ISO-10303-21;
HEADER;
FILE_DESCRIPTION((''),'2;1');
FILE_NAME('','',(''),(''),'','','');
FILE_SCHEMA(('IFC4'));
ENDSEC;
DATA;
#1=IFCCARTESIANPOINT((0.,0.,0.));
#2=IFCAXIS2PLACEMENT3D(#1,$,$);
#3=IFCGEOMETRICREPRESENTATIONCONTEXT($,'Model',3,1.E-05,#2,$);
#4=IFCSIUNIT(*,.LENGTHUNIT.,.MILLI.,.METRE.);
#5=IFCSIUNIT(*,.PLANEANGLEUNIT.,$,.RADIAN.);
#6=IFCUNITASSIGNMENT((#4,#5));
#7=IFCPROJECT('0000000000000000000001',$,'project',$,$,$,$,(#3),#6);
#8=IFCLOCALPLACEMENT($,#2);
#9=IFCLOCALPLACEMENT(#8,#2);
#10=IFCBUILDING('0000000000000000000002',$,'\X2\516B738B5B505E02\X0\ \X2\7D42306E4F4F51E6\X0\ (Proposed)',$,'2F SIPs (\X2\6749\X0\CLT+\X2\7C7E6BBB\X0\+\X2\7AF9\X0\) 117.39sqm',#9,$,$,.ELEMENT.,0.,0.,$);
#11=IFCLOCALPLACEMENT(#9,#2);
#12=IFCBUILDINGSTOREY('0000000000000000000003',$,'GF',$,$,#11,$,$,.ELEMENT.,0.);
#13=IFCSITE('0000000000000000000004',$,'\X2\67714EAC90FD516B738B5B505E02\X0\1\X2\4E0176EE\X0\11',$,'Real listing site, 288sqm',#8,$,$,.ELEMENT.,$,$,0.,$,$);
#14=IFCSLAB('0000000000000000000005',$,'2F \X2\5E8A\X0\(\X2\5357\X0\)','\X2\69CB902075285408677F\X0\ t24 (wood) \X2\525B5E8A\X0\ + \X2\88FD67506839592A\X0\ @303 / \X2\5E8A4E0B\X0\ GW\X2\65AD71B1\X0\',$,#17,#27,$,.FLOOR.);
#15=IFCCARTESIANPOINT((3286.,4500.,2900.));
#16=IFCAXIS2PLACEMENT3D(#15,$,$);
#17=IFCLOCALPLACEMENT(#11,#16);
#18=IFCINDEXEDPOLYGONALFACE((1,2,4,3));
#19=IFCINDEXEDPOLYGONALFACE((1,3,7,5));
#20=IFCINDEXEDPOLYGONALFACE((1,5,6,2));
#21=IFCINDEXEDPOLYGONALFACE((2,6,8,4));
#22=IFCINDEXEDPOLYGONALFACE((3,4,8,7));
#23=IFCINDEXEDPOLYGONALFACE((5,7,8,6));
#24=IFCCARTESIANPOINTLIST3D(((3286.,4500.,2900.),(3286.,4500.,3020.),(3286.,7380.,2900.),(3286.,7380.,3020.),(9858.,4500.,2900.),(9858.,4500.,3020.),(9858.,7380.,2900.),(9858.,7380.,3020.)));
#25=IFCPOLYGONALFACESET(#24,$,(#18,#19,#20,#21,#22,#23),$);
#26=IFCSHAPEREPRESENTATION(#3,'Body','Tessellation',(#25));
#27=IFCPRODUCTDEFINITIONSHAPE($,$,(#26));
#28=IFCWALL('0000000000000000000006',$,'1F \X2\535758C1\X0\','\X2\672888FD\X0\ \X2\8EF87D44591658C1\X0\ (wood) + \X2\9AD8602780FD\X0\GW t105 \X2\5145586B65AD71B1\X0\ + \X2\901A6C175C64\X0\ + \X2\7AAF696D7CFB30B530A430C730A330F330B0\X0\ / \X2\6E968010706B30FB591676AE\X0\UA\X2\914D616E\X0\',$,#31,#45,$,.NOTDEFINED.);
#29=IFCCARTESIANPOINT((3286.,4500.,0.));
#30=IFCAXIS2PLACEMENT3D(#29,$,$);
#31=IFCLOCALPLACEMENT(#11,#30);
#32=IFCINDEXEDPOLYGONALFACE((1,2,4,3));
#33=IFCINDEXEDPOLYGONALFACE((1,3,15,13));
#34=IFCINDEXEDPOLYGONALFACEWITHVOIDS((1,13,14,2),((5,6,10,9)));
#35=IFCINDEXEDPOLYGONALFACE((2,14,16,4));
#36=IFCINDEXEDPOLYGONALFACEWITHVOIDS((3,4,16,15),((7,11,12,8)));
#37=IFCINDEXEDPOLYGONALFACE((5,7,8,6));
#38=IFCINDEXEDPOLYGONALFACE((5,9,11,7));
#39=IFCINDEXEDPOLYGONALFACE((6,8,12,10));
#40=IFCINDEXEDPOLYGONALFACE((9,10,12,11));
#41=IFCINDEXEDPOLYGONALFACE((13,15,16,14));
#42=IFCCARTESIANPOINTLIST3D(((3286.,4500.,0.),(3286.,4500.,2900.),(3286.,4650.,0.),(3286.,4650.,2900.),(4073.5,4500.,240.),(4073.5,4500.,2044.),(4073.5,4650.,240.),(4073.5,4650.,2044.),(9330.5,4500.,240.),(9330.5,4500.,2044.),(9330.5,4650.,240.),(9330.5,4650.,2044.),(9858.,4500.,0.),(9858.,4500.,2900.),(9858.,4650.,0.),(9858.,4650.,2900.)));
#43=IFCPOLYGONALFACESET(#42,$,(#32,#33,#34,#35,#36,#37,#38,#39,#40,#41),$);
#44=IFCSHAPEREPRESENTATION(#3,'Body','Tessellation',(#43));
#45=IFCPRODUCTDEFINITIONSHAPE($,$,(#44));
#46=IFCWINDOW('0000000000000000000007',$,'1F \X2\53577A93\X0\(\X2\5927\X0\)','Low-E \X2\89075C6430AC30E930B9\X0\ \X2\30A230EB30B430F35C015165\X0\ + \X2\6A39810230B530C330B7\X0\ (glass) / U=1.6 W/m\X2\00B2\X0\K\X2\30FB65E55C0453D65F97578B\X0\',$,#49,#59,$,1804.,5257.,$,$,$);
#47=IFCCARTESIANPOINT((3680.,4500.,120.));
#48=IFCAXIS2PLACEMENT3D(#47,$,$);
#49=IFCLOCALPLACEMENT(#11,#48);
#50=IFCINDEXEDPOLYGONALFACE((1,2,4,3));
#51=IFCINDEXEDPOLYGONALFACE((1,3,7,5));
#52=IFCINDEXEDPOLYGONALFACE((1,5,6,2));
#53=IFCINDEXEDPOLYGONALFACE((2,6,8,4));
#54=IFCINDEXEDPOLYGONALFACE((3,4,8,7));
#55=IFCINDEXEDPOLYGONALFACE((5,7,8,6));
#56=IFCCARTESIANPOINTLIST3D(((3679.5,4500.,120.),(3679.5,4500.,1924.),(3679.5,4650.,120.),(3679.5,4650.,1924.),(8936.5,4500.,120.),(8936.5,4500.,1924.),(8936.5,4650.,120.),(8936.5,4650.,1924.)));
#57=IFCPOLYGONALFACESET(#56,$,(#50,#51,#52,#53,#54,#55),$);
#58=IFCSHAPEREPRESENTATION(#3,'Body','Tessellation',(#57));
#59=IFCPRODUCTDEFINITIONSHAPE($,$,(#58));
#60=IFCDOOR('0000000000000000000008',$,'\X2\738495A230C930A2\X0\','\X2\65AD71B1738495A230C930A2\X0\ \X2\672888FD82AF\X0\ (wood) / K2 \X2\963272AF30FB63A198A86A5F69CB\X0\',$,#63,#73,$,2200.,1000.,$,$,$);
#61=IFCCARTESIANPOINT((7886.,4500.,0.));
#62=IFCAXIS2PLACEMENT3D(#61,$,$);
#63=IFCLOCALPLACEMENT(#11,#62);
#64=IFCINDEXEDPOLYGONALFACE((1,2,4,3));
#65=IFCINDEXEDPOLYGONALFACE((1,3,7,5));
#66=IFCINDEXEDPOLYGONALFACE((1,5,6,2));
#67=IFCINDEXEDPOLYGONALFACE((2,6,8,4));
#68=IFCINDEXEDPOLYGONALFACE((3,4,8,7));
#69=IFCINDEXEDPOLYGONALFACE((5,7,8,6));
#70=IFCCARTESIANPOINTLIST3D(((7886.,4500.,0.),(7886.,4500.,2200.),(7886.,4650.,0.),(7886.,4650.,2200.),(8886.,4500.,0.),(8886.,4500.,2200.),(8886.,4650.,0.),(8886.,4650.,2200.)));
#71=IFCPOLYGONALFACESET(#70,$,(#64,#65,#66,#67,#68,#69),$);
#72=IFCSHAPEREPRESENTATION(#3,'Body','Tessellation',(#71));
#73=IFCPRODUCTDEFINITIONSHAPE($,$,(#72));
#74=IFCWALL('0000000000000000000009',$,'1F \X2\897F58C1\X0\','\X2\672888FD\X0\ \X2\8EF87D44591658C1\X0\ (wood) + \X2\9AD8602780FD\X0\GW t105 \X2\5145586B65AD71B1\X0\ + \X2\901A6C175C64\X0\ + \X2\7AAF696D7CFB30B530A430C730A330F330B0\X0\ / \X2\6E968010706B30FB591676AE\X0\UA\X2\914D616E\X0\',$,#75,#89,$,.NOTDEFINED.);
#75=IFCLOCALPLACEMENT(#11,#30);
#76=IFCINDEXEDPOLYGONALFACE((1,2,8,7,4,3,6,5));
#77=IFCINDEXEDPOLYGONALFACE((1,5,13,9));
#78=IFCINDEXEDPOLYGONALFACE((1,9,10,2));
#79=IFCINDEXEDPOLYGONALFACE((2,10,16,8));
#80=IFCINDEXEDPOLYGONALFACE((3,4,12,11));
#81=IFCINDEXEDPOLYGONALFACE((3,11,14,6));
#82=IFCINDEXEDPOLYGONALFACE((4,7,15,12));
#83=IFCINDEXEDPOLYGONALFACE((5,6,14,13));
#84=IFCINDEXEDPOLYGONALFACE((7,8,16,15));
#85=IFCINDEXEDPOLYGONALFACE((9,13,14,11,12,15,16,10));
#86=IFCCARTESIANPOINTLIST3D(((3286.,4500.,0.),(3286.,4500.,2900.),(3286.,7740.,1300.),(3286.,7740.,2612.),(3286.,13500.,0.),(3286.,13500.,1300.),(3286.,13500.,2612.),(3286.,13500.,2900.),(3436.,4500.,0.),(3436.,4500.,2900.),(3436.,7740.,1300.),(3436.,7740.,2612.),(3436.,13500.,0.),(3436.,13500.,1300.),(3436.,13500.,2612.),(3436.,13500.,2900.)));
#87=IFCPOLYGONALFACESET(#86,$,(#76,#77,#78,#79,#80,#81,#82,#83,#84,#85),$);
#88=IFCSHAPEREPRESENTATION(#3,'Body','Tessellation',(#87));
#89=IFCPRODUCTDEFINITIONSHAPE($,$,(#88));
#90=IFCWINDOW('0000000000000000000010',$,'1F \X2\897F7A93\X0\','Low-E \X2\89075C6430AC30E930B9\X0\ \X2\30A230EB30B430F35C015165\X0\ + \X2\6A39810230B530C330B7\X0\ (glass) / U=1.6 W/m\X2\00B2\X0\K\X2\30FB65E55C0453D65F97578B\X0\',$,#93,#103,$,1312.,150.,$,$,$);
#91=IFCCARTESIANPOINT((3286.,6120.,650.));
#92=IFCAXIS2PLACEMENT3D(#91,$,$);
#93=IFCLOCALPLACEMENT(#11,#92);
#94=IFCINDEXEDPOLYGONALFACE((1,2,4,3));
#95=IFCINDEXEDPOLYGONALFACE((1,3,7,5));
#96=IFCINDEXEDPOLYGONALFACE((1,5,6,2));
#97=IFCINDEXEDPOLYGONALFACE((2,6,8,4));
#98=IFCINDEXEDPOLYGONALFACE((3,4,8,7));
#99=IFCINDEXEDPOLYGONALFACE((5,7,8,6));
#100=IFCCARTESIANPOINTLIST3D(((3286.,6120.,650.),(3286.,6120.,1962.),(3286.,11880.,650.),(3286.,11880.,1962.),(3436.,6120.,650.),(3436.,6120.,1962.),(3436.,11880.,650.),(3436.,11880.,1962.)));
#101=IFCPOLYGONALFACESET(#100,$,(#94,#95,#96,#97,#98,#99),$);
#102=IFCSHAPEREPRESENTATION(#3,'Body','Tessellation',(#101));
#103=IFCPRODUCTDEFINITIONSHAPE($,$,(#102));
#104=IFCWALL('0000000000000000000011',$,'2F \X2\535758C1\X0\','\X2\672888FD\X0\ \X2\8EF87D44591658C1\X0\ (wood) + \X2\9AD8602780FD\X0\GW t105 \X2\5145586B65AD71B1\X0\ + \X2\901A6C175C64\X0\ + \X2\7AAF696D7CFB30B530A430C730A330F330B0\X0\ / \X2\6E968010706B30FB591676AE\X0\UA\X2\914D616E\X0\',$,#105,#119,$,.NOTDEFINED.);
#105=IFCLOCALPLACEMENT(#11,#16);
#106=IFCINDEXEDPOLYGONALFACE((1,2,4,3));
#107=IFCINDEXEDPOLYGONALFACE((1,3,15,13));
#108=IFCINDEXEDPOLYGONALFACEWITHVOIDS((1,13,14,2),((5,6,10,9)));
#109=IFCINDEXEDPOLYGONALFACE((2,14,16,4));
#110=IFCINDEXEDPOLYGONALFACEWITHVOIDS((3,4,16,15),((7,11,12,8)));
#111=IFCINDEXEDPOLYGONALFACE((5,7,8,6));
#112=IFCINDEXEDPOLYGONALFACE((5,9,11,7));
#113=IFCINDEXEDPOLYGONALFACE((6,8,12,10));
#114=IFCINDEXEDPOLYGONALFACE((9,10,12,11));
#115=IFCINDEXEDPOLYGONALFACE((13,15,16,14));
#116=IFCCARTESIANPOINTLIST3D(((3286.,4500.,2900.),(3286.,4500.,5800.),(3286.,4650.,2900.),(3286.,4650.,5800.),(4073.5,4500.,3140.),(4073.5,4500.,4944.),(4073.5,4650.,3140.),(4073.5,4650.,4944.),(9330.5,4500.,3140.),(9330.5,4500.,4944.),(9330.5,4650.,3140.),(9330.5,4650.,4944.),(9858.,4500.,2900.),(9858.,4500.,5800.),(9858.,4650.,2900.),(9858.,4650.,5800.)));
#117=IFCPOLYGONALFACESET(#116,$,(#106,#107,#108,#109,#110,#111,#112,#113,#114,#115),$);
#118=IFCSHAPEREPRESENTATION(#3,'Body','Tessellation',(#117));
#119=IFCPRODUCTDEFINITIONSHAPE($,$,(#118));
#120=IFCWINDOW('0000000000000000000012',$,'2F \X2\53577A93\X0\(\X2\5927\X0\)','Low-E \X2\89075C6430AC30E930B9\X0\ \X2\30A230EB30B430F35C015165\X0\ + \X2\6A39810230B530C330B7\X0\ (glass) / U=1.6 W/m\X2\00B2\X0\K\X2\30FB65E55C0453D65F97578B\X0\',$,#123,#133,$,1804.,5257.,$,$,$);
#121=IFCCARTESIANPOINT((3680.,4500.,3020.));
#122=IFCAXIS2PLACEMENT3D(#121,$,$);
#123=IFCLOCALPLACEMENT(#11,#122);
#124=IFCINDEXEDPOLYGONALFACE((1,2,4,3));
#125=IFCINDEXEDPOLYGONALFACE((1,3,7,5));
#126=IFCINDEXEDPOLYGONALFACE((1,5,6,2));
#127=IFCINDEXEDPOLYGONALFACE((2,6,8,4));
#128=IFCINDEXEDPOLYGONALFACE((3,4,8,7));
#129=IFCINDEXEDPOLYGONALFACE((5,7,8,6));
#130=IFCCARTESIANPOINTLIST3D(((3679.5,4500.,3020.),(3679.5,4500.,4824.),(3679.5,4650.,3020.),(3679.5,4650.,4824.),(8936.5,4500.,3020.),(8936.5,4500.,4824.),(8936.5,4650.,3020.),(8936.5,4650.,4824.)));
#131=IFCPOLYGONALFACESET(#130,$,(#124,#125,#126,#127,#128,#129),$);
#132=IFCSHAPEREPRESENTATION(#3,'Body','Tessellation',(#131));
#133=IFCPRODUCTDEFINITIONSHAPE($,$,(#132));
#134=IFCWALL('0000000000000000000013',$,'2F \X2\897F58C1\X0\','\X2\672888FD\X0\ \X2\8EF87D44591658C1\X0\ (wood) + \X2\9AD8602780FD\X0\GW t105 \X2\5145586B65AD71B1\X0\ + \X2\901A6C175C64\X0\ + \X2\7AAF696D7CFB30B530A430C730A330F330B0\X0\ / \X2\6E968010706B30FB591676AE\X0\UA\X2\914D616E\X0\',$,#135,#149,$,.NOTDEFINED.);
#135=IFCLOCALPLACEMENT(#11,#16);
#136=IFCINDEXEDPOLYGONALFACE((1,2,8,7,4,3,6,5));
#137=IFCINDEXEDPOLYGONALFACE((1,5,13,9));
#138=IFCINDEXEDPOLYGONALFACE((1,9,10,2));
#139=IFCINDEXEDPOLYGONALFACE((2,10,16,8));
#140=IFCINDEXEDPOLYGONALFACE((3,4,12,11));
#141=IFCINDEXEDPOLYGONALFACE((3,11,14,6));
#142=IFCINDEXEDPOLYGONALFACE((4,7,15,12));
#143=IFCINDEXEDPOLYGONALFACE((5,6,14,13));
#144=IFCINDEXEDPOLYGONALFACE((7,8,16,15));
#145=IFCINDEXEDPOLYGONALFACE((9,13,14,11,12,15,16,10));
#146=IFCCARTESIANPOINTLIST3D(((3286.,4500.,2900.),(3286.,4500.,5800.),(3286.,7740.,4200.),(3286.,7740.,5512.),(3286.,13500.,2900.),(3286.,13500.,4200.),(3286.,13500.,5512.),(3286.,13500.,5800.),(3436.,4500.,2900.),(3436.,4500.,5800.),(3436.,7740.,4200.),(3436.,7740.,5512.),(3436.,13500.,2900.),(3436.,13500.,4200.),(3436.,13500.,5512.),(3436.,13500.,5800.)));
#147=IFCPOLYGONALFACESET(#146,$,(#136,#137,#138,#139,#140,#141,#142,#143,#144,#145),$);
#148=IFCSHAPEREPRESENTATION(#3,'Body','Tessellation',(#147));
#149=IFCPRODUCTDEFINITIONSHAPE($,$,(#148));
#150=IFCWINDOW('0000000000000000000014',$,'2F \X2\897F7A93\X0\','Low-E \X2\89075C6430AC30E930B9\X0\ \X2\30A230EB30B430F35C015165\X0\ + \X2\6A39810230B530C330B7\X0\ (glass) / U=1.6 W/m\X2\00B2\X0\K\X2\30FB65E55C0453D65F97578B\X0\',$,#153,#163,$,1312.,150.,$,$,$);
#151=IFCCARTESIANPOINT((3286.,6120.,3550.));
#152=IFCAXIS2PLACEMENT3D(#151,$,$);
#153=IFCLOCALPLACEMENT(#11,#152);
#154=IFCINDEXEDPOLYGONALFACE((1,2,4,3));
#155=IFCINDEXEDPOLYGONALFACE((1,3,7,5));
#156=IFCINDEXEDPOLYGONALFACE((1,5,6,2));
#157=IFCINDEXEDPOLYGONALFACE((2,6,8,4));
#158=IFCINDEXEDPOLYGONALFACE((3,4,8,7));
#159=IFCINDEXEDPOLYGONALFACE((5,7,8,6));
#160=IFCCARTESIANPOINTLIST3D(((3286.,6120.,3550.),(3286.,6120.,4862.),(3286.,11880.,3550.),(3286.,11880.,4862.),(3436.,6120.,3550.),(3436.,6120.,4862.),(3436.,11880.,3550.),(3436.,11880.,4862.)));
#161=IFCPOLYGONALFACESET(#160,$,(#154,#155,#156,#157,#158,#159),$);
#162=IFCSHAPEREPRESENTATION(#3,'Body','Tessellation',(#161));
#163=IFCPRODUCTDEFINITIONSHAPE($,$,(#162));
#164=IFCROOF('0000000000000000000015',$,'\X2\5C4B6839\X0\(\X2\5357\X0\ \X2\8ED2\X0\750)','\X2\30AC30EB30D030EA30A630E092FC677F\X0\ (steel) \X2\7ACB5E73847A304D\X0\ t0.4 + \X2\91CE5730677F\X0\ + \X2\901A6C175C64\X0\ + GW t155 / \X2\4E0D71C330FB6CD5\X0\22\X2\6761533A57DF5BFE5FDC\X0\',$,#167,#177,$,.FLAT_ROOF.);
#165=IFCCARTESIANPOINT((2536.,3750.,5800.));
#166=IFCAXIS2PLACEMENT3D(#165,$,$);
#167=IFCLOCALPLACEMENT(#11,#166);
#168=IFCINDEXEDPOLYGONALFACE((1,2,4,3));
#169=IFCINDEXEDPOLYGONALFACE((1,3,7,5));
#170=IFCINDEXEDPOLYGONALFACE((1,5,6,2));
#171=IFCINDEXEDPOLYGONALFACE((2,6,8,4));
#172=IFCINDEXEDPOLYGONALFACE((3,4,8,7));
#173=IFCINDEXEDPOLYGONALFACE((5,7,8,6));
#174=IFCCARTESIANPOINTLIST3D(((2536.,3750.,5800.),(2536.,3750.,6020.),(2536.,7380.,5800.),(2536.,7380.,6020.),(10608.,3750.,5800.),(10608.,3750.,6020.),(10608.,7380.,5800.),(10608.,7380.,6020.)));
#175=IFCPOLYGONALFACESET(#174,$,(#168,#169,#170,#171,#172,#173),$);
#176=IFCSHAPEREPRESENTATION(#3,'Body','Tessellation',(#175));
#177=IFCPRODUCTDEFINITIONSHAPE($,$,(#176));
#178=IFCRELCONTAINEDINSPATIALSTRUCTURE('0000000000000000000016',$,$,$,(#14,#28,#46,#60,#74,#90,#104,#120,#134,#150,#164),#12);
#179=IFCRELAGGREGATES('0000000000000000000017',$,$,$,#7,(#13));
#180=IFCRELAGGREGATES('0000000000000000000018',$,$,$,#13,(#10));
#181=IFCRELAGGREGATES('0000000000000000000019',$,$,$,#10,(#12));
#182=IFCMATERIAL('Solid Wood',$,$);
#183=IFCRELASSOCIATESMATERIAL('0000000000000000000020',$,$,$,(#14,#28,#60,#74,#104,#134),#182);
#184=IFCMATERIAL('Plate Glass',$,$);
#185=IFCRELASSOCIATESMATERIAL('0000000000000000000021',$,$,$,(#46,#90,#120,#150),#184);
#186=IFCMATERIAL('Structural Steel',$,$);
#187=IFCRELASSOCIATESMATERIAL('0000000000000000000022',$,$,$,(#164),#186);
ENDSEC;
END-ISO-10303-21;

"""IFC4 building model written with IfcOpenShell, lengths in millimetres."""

from ifc_helpers import new_model, si_unit, frame, frame_2d, origin, place, context, project, spatial, rectangle, extrude, material, element, fill, save


model = new_model("IFC4")

# Units and contexts
model_context = context("Model", 3, precision=1e-05, world=origin())
ifc_project = project(units=[si_unit("LENGTHUNIT", "METRE", prefix="MILLI"), si_unit("PLANEANGLEUNIT", "RADIAN")], contexts=[model_context])

# Site, building, storey
site_placement = place(None, origin())
site = spatial("IfcSite", under=ifc_project, at=site_placement, Name="東京都八王子市1丁目11", ObjectType="Real listing site, 288sqm", CompositionType="ELEMENT", RefElevation=0.0)
building_placement = place(site_placement, origin())
building = spatial("IfcBuilding", under=site, at=building_placement, Name="八王子市 終の住処 (Proposed)", ObjectType="2F SIPs (杉CLT+籾殻+竹) 117.39sqm", CompositionType="ELEMENT", ElevationOfRefHeight=0.0, ElevationOfTerrain=0.0)
storey_placement = place(building_placement, origin())
storey = spatial("IfcBuildingStorey", under=building, at=storey_placement, Name="GF", CompositionType="ELEMENT", Elevation=0.0)

# Slab
ifc_material_1 = material(Name="Solid Wood")
slab_1_placement = place(storey_placement, frame((3286.0, 4500.0, 2900.0)))
element("IfcSlab", 1, at=slab_1_placement, inside=storey, material=ifc_material_1, Name="2F 床(南)", Description="構造用合板 t24 (wood) 剛床 + 製材根太 @303 / 床下 GW断熱", PredefinedType="FLOOR", context=model_context, shape_type="SweptSolid", body=[
    extrude(rectangle(XDim=6572.0, YDim=2880.0, at=frame_2d((3286.0, 1440.0))), frame((3286.0, 4500.0, 2900.0)), (0.0, 0.0, 1.0), 120.0),
])

# Wall, openings, window, door
wall_1_placement = place(storey_placement, frame((3286.0, 4500.0, 0.0)))
wall_1 = element("IfcWall", 2, at=wall_1_placement, inside=storey, material=ifc_material_1, Name="1F 南壁", Description="木製 軸組外壁 (wood) + 高性能GW t105 充填断熱 + 通気層 + 窯業系サイディング / 準耐火・外皮UA配慮", PredefinedType="NOTDEFINED", context=model_context, shape_type="SweptSolid", body=[
    extrude(rectangle(XDim=6572.0, YDim=150.0, at=frame_2d((3286.0, 75.0))), frame((3286.0, 4500.0, 0.0)), (0.0, 0.0, 1.0), 2900.0),
])
opening_1_placement = place(storey_placement, frame((3680.0, 4500.0, 120.0)))
opening_1 = element("IfcOpeningElement", 3, at=opening_1_placement, cuts=wall_1, PredefinedType="NOTDEFINED", context=model_context, shape_type="SweptSolid", body=[
    extrude(rectangle(XDim=5257.0, YDim=150.0, at=frame_2d((2628.0, 75.0))), frame((3680.0, 4500.0, 120.0)), (0.0, 0.0, 1.0), 1804.0),
])
opening_2_placement = place(storey_placement, frame((7886.0, 4500.0, 0.0)))
opening_2 = element("IfcOpeningElement", 4, at=opening_2_placement, cuts=wall_1, PredefinedType="NOTDEFINED", context=model_context, shape_type="SweptSolid", body=[
    extrude(rectangle(XDim=1000.0, YDim=150.0, at=frame_2d((500.0, 75.0))), frame((7886.0, 4500.0, 0.0)), (0.0, 0.0, 1.0), 2200.0),
])
ifc_material_2 = material(Name="Plate Glass")
window_1_placement = place(storey_placement, frame((3680.0, 4500.0, 120.0)))
window_1 = element("IfcWindow", 5, at=window_1_placement, inside=storey, material=ifc_material_2, Name="1F 南窓(大)", Description="Low-E 複層ガラス アルゴン封入 + 樹脂サッシ (glass) / U=1.6 W/m²K・日射取得型", OverallHeight=1804.0, OverallWidth=5257.0, context=model_context, shape_type="SweptSolid", body=[
    extrude(rectangle(XDim=5257.0, YDim=150.0, at=frame_2d((2628.0, 75.0))), frame((3680.0, 4500.0, 120.0)), (0.0, 0.0, 1.0), 1804.0),
])
fill(opening_1, window_1)
door_placement = place(storey_placement, frame((7886.0, 4500.0, 0.0)))
door = element("IfcDoor", 6, at=door_placement, inside=storey, material=ifc_material_1, Name="玄関ドア", Description="断熱玄関ドア 木製芯 (wood) / K2 防犯・採風機構", OverallHeight=2200.0, OverallWidth=1000.0, context=model_context, shape_type="SweptSolid", body=[
    extrude(rectangle(XDim=1000.0, YDim=150.0, at=frame_2d((500.0, 75.0))), frame((7886.0, 4500.0, 0.0)), (0.0, 0.0, 1.0), 2200.0),
])
fill(opening_2, door)

# Walls, openings, windows
wall_2_placement = place(storey_placement, frame((3286.0, 4500.0, 0.0)))
wall_2 = element("IfcWall", 7, at=wall_2_placement, inside=storey, material=ifc_material_1, Name="1F 西壁", Description="木製 軸組外壁 (wood) + 高性能GW t105 充填断熱 + 通気層 + 窯業系サイディング / 準耐火・外皮UA配慮", PredefinedType="NOTDEFINED", context=model_context, shape_type="SweptSolid", body=[
    extrude(rectangle(XDim=150.0, YDim=9000.0, at=frame_2d((75.0, 4500.0))), frame((3286.0, 4500.0, 0.0)), (0.0, 0.0, 1.0), 2900.0),
])
opening_3_placement = place(storey_placement, frame((3286.0, 6120.0, 650.0)))
opening_3 = element("IfcOpeningElement", 8, at=opening_3_placement, cuts=wall_2, PredefinedType="NOTDEFINED", context=model_context, shape_type="SweptSolid", body=[
    extrude(rectangle(XDim=150.0, YDim=5760.0, at=frame_2d((75.0, 2880.0))), frame((3286.0, 6120.0, 650.0)), (0.0, 0.0, 1.0), 1312.0),
])
window_2_placement = place(storey_placement, frame((3286.0, 6120.0, 650.0)))
window_2 = element("IfcWindow", 9, at=window_2_placement, inside=storey, material=ifc_material_2, Name="1F 西窓", Description="Low-E 複層ガラス アルゴン封入 + 樹脂サッシ (glass) / U=1.6 W/m²K・日射取得型", OverallHeight=1312.0, OverallWidth=150.0, context=model_context, shape_type="SweptSolid", body=[
    extrude(rectangle(XDim=150.0, YDim=5760.0, at=frame_2d((75.0, 2880.0))), frame((3286.0, 6120.0, 650.0)), (0.0, 0.0, 1.0), 1312.0),
])
fill(opening_3, window_2)
wall_3_placement = place(storey_placement, frame((3286.0, 4500.0, 2900.0)))
wall_3 = element("IfcWall", 10, at=wall_3_placement, inside=storey, material=ifc_material_1, Name="2F 南壁", Description="木製 軸組外壁 (wood) + 高性能GW t105 充填断熱 + 通気層 + 窯業系サイディング / 準耐火・外皮UA配慮", PredefinedType="NOTDEFINED", context=model_context, shape_type="SweptSolid", body=[
    extrude(rectangle(XDim=6572.0, YDim=150.0, at=frame_2d((3286.0, 75.0))), frame((3286.0, 4500.0, 2900.0)), (0.0, 0.0, 1.0), 2900.0),
])
opening_4_placement = place(storey_placement, frame((3680.0, 4500.0, 3020.0)))
opening_4 = element("IfcOpeningElement", 11, at=opening_4_placement, cuts=wall_3, PredefinedType="NOTDEFINED", context=model_context, shape_type="SweptSolid", body=[
    extrude(rectangle(XDim=5257.0, YDim=150.0, at=frame_2d((2628.0, 75.0))), frame((3680.0, 4500.0, 3020.0)), (0.0, 0.0, 1.0), 1804.0),
])
window_3_placement = place(storey_placement, frame((3680.0, 4500.0, 3020.0)))
window_3 = element("IfcWindow", 12, at=window_3_placement, inside=storey, material=ifc_material_2, Name="2F 南窓(大)", Description="Low-E 複層ガラス アルゴン封入 + 樹脂サッシ (glass) / U=1.6 W/m²K・日射取得型", OverallHeight=1804.0, OverallWidth=5257.0, context=model_context, shape_type="SweptSolid", body=[
    extrude(rectangle(XDim=5257.0, YDim=150.0, at=frame_2d((2628.0, 75.0))), frame((3680.0, 4500.0, 3020.0)), (0.0, 0.0, 1.0), 1804.0),
])
fill(opening_4, window_3)
wall_4_placement = place(storey_placement, frame((3286.0, 4500.0, 2900.0)))
wall_4 = element("IfcWall", 13, at=wall_4_placement, inside=storey, material=ifc_material_1, Name="2F 西壁", Description="木製 軸組外壁 (wood) + 高性能GW t105 充填断熱 + 通気層 + 窯業系サイディング / 準耐火・外皮UA配慮", PredefinedType="NOTDEFINED", context=model_context, shape_type="SweptSolid", body=[
    extrude(rectangle(XDim=150.0, YDim=9000.0, at=frame_2d((75.0, 4500.0))), frame((3286.0, 4500.0, 2900.0)), (0.0, 0.0, 1.0), 2900.0),
])
opening_5_placement = place(storey_placement, frame((3286.0, 6120.0, 3550.0)))
opening_5 = element("IfcOpeningElement", 14, at=opening_5_placement, cuts=wall_4, PredefinedType="NOTDEFINED", context=model_context, shape_type="SweptSolid", body=[
    extrude(rectangle(XDim=150.0, YDim=5760.0, at=frame_2d((75.0, 2880.0))), frame((3286.0, 6120.0, 3550.0)), (0.0, 0.0, 1.0), 1312.0),
])
window_4_placement = place(storey_placement, frame((3286.0, 6120.0, 3550.0)))
window_4 = element("IfcWindow", 15, at=window_4_placement, inside=storey, material=ifc_material_2, Name="2F 西窓", Description="Low-E 複層ガラス アルゴン封入 + 樹脂サッシ (glass) / U=1.6 W/m²K・日射取得型", OverallHeight=1312.0, OverallWidth=150.0, context=model_context, shape_type="SweptSolid", body=[
    extrude(rectangle(XDim=150.0, YDim=5760.0, at=frame_2d((75.0, 2880.0))), frame((3286.0, 6120.0, 3550.0)), (0.0, 0.0, 1.0), 1312.0),
])
fill(opening_5, window_4)

# Roof
ifc_material_3 = material(Name="Structural Steel")
roof_1_placement = place(storey_placement, frame((2536.0, 3750.0, 5800.0)))
element("IfcRoof", 16, at=roof_1_placement, inside=storey, material=ifc_material_3, Name="屋根(南 軒750)", Description="ガルバリウム鋼板 (steel) 立平葺き t0.4 + 野地板 + 通気層 + GW t155 / 不燃・法22条区域対応", PredefinedType="FLAT_ROOF", context=model_context, shape_type="SweptSolid", body=[
    extrude(rectangle(XDim=8072.0, YDim=3630.0, at=frame_2d((4036.0, 1815.0))), frame((2536.0, 3750.0, 5800.0)), (0.0, 0.0, 1.0), 220.0),
])

save(model, "model.ifc")
